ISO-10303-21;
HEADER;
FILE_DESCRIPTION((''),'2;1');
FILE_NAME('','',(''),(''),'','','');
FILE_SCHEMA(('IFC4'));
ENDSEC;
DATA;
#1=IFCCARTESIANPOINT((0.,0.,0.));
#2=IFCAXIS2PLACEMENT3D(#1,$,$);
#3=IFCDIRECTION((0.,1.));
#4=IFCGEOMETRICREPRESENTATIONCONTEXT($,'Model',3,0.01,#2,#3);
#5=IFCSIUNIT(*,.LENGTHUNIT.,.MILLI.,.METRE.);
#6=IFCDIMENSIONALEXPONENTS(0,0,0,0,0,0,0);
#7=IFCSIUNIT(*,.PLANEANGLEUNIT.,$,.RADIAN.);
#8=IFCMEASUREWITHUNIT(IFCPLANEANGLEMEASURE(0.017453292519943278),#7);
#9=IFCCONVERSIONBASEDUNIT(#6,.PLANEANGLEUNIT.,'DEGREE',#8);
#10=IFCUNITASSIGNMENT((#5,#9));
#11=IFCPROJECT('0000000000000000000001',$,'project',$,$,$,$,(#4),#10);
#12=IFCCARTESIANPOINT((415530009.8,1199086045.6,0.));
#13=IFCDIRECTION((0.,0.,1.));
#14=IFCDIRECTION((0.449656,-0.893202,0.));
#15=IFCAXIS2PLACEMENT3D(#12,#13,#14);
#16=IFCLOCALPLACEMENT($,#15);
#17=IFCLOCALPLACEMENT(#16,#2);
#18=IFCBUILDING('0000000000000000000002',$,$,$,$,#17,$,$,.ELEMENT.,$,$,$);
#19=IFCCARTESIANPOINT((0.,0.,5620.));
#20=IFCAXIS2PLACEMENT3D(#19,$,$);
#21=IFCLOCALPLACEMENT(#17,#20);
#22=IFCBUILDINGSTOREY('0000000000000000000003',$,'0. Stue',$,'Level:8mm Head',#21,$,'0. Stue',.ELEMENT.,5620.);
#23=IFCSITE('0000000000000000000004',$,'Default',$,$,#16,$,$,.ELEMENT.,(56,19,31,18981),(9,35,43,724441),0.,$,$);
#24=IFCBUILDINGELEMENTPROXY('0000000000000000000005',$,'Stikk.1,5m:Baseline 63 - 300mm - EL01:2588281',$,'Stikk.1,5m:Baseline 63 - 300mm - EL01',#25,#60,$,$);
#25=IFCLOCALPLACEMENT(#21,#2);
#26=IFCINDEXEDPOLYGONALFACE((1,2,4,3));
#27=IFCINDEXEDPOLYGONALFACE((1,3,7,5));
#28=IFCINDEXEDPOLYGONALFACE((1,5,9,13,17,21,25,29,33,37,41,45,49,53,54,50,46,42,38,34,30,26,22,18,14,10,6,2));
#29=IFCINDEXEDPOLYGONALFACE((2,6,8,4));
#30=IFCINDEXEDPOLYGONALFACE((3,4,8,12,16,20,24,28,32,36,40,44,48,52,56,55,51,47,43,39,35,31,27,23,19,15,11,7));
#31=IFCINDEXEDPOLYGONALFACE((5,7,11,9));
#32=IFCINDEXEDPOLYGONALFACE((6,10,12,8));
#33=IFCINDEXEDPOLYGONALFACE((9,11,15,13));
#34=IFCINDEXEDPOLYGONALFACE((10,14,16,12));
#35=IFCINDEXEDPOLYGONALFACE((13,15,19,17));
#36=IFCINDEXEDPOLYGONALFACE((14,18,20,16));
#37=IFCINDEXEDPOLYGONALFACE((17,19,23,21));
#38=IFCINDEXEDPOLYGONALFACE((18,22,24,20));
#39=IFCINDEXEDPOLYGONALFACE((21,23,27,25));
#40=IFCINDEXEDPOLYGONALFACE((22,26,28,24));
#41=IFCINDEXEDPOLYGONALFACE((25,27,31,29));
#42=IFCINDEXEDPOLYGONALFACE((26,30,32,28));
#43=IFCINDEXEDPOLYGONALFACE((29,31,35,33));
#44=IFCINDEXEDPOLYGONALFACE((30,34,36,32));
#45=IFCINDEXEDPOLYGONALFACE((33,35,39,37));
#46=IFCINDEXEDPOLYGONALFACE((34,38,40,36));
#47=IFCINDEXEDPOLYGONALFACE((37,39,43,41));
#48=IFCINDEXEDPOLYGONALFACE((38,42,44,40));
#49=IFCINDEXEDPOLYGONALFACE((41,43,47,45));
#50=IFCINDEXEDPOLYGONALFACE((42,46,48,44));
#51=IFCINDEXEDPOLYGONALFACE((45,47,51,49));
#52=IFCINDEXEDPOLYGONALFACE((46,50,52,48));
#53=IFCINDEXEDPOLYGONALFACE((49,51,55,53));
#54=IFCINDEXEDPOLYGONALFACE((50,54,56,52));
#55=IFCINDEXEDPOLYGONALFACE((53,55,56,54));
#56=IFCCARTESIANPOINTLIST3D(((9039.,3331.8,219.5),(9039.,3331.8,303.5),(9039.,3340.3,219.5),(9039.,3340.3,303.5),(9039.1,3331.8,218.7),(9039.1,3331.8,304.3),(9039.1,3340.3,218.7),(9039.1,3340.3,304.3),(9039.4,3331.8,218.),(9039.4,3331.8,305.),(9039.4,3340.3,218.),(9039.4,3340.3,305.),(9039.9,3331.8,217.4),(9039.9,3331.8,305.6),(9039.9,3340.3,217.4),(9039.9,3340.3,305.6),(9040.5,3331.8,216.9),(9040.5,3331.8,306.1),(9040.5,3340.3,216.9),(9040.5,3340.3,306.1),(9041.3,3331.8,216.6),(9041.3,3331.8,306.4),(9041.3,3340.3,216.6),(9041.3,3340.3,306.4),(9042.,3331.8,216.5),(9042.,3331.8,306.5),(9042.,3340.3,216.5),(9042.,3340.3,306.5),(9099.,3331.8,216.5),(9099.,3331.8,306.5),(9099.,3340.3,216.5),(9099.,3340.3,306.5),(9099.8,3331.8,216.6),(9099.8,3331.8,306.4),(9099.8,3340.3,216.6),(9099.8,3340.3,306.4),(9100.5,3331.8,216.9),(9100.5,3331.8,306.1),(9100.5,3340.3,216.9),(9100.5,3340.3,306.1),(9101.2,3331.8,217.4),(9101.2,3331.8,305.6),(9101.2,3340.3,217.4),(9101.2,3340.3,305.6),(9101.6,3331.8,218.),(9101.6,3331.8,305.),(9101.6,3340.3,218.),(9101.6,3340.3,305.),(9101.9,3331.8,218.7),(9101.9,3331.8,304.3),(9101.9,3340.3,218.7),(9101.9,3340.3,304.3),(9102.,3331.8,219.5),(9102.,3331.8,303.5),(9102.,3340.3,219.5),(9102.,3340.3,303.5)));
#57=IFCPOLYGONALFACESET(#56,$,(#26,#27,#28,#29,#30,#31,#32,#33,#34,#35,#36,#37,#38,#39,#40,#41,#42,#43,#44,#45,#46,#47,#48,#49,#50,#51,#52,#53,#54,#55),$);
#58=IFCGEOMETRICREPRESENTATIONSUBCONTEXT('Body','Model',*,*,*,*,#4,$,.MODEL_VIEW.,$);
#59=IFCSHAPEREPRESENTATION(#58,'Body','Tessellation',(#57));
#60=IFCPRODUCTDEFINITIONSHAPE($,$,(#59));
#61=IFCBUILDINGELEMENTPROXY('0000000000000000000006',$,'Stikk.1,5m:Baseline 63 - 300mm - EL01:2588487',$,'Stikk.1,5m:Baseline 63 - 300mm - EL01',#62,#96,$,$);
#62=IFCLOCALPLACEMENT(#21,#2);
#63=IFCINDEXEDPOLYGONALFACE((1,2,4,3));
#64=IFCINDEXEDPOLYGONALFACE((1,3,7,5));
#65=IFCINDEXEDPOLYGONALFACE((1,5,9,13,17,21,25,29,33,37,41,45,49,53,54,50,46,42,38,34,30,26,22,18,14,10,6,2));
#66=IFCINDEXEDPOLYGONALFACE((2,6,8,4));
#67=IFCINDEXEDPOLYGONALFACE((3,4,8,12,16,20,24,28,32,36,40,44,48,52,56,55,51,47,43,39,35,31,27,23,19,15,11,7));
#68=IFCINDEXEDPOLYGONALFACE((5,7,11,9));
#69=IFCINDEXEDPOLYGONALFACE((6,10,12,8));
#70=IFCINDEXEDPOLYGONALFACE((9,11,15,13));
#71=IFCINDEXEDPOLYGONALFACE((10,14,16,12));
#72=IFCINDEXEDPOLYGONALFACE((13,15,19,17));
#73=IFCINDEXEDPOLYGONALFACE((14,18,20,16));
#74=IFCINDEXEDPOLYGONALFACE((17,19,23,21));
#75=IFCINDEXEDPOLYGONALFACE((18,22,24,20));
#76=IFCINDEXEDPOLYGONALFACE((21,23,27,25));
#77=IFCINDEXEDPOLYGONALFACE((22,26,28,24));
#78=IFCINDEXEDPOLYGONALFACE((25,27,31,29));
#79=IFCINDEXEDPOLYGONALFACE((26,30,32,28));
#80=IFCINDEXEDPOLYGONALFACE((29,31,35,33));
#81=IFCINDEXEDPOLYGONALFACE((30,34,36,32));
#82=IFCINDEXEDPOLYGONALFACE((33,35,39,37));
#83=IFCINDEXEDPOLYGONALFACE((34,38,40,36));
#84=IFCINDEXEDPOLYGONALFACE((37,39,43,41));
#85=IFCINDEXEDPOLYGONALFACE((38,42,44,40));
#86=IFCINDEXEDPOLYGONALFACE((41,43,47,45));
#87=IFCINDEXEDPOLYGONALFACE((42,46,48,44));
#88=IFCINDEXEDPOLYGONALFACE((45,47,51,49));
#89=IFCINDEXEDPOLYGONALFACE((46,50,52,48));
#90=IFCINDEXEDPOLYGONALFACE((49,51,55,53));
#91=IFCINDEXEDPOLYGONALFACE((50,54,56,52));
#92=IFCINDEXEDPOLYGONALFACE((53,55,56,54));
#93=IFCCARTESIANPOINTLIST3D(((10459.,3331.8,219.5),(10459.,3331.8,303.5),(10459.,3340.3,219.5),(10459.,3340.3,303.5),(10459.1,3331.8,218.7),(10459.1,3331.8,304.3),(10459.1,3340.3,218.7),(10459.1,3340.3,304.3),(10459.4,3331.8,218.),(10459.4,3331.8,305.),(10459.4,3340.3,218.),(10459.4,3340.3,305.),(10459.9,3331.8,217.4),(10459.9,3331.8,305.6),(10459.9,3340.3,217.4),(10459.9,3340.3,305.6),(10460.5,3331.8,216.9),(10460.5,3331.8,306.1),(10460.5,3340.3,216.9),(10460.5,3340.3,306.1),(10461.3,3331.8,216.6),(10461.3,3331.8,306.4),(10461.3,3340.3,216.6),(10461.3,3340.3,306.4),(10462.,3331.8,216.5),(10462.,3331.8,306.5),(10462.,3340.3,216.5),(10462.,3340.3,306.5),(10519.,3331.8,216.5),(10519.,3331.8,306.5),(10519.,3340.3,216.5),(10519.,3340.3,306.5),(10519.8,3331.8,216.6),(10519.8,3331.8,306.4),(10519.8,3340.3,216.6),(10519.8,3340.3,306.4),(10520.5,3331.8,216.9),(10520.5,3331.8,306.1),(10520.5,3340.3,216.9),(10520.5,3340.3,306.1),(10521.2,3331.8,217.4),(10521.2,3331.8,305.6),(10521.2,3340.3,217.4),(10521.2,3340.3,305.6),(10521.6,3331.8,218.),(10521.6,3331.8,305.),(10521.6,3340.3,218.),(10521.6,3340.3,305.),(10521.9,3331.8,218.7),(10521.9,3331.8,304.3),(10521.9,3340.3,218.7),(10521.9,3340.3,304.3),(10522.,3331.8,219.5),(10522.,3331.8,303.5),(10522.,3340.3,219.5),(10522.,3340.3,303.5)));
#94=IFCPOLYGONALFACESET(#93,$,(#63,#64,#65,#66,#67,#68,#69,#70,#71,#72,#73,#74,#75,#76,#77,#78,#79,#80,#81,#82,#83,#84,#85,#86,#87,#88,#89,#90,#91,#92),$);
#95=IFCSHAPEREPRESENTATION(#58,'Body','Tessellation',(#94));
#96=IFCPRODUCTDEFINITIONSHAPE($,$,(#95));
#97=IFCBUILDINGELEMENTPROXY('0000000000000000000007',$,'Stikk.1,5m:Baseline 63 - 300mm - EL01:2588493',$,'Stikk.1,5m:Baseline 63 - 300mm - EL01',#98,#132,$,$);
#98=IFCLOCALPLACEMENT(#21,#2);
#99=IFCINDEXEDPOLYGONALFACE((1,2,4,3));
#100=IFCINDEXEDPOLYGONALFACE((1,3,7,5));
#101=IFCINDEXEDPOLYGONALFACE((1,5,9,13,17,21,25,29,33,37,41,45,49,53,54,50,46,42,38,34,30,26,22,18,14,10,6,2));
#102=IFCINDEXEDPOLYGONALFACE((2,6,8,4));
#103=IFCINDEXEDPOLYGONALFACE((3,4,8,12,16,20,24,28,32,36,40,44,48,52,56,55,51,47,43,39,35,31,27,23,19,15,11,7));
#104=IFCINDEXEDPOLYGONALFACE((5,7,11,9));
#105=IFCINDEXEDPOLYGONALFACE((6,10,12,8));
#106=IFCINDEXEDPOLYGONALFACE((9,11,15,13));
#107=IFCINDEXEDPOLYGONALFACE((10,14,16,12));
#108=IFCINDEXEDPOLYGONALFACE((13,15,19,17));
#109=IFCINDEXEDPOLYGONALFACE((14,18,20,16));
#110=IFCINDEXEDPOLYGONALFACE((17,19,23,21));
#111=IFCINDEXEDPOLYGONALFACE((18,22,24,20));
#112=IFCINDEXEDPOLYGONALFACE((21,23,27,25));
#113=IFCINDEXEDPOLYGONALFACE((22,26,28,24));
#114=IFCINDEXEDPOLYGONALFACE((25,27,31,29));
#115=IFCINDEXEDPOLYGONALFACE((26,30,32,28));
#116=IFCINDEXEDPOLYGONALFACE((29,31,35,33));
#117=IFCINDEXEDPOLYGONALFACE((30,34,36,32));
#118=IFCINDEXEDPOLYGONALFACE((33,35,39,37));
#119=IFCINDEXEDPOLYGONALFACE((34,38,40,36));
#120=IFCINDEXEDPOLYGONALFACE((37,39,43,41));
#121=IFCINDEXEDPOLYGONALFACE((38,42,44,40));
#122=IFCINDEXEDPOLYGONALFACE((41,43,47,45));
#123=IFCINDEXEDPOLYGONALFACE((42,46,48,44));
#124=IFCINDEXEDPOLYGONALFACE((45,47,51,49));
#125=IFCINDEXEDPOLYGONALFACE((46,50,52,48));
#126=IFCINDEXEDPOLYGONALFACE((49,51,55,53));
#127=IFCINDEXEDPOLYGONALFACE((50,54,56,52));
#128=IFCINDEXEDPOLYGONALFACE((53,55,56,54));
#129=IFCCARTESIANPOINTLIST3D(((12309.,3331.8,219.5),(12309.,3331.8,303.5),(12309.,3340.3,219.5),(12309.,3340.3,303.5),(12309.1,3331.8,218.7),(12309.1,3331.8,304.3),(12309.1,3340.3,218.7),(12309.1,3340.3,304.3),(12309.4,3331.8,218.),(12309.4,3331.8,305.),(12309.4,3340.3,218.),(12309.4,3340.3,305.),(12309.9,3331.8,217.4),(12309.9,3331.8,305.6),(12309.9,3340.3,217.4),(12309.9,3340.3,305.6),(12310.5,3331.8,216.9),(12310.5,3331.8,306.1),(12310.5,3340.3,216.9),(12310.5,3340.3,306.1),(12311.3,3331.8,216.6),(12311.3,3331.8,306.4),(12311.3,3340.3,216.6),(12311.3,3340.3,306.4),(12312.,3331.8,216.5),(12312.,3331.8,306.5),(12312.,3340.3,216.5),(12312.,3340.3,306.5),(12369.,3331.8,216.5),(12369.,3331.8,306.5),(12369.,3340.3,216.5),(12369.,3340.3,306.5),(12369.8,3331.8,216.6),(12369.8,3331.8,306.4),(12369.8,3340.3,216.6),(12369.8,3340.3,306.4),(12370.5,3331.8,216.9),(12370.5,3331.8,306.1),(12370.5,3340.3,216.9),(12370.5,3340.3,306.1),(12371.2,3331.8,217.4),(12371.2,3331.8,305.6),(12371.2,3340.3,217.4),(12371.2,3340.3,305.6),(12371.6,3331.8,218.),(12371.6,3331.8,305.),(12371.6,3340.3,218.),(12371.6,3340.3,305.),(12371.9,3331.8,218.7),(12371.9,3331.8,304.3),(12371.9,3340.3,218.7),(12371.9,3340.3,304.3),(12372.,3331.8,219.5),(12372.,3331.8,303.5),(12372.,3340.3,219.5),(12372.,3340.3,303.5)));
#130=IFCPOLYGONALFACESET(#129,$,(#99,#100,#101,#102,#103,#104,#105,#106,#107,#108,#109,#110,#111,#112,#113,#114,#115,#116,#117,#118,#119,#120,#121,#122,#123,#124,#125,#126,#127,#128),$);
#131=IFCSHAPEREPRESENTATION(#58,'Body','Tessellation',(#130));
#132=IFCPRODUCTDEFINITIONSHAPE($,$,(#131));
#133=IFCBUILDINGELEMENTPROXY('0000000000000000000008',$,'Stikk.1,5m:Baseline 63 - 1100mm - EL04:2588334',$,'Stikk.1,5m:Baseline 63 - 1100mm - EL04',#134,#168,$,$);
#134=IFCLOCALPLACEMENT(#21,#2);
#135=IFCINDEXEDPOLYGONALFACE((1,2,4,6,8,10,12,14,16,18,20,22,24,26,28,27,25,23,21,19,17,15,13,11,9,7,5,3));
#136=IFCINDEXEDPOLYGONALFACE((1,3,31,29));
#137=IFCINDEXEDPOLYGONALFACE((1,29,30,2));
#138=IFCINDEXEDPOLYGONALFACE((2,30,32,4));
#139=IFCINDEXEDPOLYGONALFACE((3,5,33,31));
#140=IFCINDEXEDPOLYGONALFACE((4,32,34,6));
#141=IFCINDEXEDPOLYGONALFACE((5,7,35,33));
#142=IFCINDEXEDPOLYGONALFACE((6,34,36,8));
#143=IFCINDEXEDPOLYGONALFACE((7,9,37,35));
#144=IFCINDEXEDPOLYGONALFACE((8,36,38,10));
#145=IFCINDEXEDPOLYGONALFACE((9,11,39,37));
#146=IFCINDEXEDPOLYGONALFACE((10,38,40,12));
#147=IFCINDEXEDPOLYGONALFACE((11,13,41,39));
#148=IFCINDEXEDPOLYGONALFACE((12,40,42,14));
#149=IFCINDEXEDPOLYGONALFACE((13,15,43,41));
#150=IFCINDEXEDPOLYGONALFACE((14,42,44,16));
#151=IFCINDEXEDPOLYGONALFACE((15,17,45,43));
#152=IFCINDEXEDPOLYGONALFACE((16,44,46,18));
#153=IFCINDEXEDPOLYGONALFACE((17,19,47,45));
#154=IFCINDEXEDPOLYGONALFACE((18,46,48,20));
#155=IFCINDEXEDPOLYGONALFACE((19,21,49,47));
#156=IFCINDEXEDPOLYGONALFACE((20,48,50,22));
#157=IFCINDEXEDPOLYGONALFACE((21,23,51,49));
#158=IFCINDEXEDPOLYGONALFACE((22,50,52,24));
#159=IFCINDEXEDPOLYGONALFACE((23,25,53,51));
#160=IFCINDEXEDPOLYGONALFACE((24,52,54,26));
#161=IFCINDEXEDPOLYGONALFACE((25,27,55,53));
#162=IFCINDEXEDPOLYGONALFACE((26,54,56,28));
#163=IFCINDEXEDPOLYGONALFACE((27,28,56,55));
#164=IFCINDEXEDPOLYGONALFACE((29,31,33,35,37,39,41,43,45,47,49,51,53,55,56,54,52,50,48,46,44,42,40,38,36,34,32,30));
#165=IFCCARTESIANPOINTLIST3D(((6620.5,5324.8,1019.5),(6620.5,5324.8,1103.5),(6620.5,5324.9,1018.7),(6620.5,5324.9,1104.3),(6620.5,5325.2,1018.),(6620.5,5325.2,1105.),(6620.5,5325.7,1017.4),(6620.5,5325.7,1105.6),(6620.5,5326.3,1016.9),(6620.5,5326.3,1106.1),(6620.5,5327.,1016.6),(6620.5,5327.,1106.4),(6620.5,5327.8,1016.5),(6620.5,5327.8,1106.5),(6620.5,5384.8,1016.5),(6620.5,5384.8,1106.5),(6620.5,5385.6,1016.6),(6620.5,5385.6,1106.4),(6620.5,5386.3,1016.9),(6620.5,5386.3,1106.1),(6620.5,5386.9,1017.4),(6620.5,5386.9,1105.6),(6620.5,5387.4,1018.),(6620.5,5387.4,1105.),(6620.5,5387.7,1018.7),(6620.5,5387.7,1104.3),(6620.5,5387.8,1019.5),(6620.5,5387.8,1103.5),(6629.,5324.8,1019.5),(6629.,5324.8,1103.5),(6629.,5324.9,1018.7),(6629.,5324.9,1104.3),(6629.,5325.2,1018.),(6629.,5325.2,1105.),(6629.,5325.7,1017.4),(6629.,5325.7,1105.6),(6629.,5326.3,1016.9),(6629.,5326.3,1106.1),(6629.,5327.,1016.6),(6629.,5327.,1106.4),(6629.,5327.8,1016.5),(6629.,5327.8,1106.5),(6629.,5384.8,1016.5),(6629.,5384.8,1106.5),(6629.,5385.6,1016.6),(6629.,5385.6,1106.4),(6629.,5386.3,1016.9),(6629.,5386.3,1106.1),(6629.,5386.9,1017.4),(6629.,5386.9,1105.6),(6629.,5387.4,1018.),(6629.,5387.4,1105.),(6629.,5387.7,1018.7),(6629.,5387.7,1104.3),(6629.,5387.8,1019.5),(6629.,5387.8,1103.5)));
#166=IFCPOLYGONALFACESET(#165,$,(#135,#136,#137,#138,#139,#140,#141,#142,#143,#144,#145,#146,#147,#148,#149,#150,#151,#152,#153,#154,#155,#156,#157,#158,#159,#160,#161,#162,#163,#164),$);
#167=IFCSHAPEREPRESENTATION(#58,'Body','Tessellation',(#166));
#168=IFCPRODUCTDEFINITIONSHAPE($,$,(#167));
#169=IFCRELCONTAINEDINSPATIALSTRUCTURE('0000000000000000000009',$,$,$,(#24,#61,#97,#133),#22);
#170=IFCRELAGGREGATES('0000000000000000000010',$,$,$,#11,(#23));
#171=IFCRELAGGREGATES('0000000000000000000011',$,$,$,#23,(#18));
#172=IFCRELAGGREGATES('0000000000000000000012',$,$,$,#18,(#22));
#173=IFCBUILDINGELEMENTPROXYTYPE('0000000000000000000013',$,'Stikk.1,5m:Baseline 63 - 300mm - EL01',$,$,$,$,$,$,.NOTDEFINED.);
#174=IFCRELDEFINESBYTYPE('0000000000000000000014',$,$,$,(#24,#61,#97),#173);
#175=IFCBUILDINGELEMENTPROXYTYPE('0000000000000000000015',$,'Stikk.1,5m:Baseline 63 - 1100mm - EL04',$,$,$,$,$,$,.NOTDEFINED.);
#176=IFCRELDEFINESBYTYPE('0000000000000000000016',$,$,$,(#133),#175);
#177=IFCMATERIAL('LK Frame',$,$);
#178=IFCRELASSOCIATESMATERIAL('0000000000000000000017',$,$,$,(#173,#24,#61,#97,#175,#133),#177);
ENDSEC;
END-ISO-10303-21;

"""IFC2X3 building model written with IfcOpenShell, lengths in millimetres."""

from ifc_helpers import new_model, entity, si_unit, converted_unit, direction, frame, frame_2d, origin, place, context, subcontext, project, spatial, polyline, circle_curve, parameter, trimmed, segment, composite_curve, outline, extrude, source, transform, mapped, material, type_object, type_shapes, element, save


model = new_model("IFC2X3")

# Units and contexts
model_context = context("Model", 3, precision=0.01, world=origin(), true_north=direction((0.0, 1.0)))
body_context = subcontext(model_context, "Body", "Model", "MODEL_VIEW")
ifc_project = project(units=[si_unit("LENGTHUNIT", "METRE", prefix="MILLI"), converted_unit("PLANEANGLEUNIT", "DEGREE", entity("IfcPlaneAngleMeasure", 0.017453292519943278), si_unit("PLANEANGLEUNIT", "RADIAN"), dimensions=[0, 0, 0, 0, 0, 0, 0])], contexts=[model_context])

# Site, building, storey
site_placement = place(None, frame((415530009.8, 1199086045.6, 0.0), z_axis=(0.0, 0.0, 1.0), x_axis=(0.449656, -0.893202, 0.0)))
site = spatial("IfcSite", under=ifc_project, at=site_placement, Name="Default", CompositionType="ELEMENT", RefLatitude=(56, 19, 31, 18981), RefLongitude=(9, 35, 43, 724441), RefElevation=0.0)
building_placement = place(site_placement, origin())
building = spatial("IfcBuilding", under=site, at=building_placement, CompositionType="ELEMENT")
storey_placement = place(building_placement, frame((0.0, 0.0, 5620.0)))
storey = spatial("IfcBuildingStorey", under=building, at=storey_placement, Name="0. Stue", ObjectType="Level:8mm Head", LongName="0. Stue", CompositionType="ELEMENT", Elevation=5620.0)

# Building element proxies
ifc_material_1 = material(Name="LK Frame")
building_element_proxy_type_1 = type_object("IfcBuildingElementProxyType", Name="Stikk.1,5m:Baseline 63 - 300mm - EL01", PredefinedType="NOTDEFINED", material=ifc_material_1)
shared_shape_1 = source(origin(), body_context, "Body", "SweptSolid", [
    extrude(outline(composite_curve([segment(polyline([(-42.0, -31.5), (42.0, -31.5)]), True, "CONTINUOUS"), segment(trimmed(circle_curve(frame_2d((42.0, -28.5), x_axis=(-1.0, 0.0)), 3.0), [parameter(90.0)], [parameter(180.0)], True, "PARAMETER"), True, "CONTINUOUS"), segment(polyline([(45.0, -28.5), (45.0, 28.5)]), True, "CONTINUOUS"), segment(trimmed(circle_curve(frame_2d((42.0, 28.5), x_axis=(-1.0, 0.0)), 3.0), [parameter(180.0)], [parameter(270.0)], True, "PARAMETER"), True, "CONTINUOUS"), segment(polyline([(42.0, 31.5), (-42.0, 31.5)]), True, "CONTINUOUS"), segment(trimmed(circle_curve(frame_2d((-42.0, 28.5), x_axis=(1.0, 0.0)), 3.0), [parameter(90.0)], [parameter(180.0)], True, "PARAMETER"), True, "CONTINUOUS"), segment(polyline([(-45.0, 28.5), (-45.0, -28.5)]), True, "CONTINUOUS"), segment(trimmed(circle_curve(frame_2d((-42.0, -28.5), x_axis=(1.0, 0.0)), 3.0), [parameter(180.0)], [parameter(270.0)], True, "PARAMETER"), True, "CONTINUOUS")], self_intersect=False)), frame((0.0, -38.5, 0.0), z_axis=(0.0, 0.0, 1.0), x_axis=(0.0, 1.0, 0.0)), (0.0, 0.0, 1.0), 8.5),
])
type_shapes(building_element_proxy_type_1, [shared_shape_1])
for number, where, z_axis, x_axis, name in (
    (1, (9070.5, 3331.8, 300.0), (0.0, 1.0, 0.0), (-1.0, 0.0, 0.0), "Stikk.1,5m:Baseline 63 - 300mm - EL01:2588281"),
    (2, (10490.5, 3331.8, 300.0), (0.0, 1.0, 0.0), (-1.0, 0.0, 0.0), "Stikk.1,5m:Baseline 63 - 300mm - EL01:2588487"),
    (3, (12340.5, 3331.8, 300.0), (0.0, 1.0, 0.0), (-1.0, 0.0, 0.0), "Stikk.1,5m:Baseline 63 - 300mm - EL01:2588493"),
):
    element("IfcBuildingElementProxy", number, at=place(storey_placement, frame(where, z_axis=z_axis, x_axis=x_axis)), inside=storey, type_object=building_element_proxy_type_1, material=ifc_material_1, Name=name, ObjectType="Stikk.1,5m:Baseline 63 - 300mm - EL01", context=body_context, shape_type="MappedRepresentation", body=[
        mapped(shared_shape_1, transform((0.0, 0.0, 0.0), scale=1.0)),
    ])
building_element_proxy_type_2 = type_object("IfcBuildingElementProxyType", Name="Stikk.1,5m:Baseline 63 - 1100mm - EL04", PredefinedType="NOTDEFINED", material=ifc_material_1)
shared_shape_2 = source(origin(), body_context, "Body", "SweptSolid", [
    extrude(outline(composite_curve([segment(polyline([(-42.0, -31.5), (42.0, -31.5)]), True, "CONTINUOUS"), segment(trimmed(circle_curve(frame_2d((42.0, -28.5), x_axis=(-1.0, 0.0)), 3.0), [parameter(90.0)], [parameter(180.0)], True, "PARAMETER"), True, "CONTINUOUS"), segment(polyline([(45.0, -28.5), (45.0, 28.5)]), True, "CONTINUOUS"), segment(trimmed(circle_curve(frame_2d((42.0, 28.5), x_axis=(-1.0, 0.0)), 3.0), [parameter(180.0)], [parameter(270.0)], True, "PARAMETER"), True, "CONTINUOUS"), segment(polyline([(42.0, 31.5), (-42.0, 31.5)]), True, "CONTINUOUS"), segment(trimmed(circle_curve(frame_2d((-42.0, 28.5), x_axis=(1.0, 0.0)), 3.0), [parameter(90.0)], [parameter(180.0)], True, "PARAMETER"), True, "CONTINUOUS"), segment(polyline([(-45.0, 28.5), (-45.0, -28.5)]), True, "CONTINUOUS"), segment(trimmed(circle_curve(frame_2d((-42.0, -28.5), x_axis=(1.0, 0.0)), 3.0), [parameter(180.0)], [parameter(270.0)], True, "PARAMETER"), True, "CONTINUOUS")], self_intersect=False)), frame((0.0, -38.5, 0.0), z_axis=(0.0, 0.0, 1.0), x_axis=(0.0, 1.0, 0.0)), (0.0, 0.0, 1.0), 8.5),
])
type_shapes(building_element_proxy_type_2, [shared_shape_2])
for number, where, z_axis, x_axis, name in (
    (4, (6620.5, 5356.3, 1100.0), (1.0, 0.0, 0.0), (0.0, 1.0, 0.0), "Stikk.1,5m:Baseline 63 - 1100mm - EL04:2588334"),
):
    element("IfcBuildingElementProxy", number, at=place(storey_placement, frame(where, z_axis=z_axis, x_axis=x_axis)), inside=storey, type_object=building_element_proxy_type_2, material=ifc_material_1, Name=name, ObjectType="Stikk.1,5m:Baseline 63 - 1100mm - EL04", context=body_context, shape_type="MappedRepresentation", body=[
        mapped(shared_shape_2, transform((0.0, 0.0, 0.0), scale=1.0)),
    ])

save(model, "model.ifc")
